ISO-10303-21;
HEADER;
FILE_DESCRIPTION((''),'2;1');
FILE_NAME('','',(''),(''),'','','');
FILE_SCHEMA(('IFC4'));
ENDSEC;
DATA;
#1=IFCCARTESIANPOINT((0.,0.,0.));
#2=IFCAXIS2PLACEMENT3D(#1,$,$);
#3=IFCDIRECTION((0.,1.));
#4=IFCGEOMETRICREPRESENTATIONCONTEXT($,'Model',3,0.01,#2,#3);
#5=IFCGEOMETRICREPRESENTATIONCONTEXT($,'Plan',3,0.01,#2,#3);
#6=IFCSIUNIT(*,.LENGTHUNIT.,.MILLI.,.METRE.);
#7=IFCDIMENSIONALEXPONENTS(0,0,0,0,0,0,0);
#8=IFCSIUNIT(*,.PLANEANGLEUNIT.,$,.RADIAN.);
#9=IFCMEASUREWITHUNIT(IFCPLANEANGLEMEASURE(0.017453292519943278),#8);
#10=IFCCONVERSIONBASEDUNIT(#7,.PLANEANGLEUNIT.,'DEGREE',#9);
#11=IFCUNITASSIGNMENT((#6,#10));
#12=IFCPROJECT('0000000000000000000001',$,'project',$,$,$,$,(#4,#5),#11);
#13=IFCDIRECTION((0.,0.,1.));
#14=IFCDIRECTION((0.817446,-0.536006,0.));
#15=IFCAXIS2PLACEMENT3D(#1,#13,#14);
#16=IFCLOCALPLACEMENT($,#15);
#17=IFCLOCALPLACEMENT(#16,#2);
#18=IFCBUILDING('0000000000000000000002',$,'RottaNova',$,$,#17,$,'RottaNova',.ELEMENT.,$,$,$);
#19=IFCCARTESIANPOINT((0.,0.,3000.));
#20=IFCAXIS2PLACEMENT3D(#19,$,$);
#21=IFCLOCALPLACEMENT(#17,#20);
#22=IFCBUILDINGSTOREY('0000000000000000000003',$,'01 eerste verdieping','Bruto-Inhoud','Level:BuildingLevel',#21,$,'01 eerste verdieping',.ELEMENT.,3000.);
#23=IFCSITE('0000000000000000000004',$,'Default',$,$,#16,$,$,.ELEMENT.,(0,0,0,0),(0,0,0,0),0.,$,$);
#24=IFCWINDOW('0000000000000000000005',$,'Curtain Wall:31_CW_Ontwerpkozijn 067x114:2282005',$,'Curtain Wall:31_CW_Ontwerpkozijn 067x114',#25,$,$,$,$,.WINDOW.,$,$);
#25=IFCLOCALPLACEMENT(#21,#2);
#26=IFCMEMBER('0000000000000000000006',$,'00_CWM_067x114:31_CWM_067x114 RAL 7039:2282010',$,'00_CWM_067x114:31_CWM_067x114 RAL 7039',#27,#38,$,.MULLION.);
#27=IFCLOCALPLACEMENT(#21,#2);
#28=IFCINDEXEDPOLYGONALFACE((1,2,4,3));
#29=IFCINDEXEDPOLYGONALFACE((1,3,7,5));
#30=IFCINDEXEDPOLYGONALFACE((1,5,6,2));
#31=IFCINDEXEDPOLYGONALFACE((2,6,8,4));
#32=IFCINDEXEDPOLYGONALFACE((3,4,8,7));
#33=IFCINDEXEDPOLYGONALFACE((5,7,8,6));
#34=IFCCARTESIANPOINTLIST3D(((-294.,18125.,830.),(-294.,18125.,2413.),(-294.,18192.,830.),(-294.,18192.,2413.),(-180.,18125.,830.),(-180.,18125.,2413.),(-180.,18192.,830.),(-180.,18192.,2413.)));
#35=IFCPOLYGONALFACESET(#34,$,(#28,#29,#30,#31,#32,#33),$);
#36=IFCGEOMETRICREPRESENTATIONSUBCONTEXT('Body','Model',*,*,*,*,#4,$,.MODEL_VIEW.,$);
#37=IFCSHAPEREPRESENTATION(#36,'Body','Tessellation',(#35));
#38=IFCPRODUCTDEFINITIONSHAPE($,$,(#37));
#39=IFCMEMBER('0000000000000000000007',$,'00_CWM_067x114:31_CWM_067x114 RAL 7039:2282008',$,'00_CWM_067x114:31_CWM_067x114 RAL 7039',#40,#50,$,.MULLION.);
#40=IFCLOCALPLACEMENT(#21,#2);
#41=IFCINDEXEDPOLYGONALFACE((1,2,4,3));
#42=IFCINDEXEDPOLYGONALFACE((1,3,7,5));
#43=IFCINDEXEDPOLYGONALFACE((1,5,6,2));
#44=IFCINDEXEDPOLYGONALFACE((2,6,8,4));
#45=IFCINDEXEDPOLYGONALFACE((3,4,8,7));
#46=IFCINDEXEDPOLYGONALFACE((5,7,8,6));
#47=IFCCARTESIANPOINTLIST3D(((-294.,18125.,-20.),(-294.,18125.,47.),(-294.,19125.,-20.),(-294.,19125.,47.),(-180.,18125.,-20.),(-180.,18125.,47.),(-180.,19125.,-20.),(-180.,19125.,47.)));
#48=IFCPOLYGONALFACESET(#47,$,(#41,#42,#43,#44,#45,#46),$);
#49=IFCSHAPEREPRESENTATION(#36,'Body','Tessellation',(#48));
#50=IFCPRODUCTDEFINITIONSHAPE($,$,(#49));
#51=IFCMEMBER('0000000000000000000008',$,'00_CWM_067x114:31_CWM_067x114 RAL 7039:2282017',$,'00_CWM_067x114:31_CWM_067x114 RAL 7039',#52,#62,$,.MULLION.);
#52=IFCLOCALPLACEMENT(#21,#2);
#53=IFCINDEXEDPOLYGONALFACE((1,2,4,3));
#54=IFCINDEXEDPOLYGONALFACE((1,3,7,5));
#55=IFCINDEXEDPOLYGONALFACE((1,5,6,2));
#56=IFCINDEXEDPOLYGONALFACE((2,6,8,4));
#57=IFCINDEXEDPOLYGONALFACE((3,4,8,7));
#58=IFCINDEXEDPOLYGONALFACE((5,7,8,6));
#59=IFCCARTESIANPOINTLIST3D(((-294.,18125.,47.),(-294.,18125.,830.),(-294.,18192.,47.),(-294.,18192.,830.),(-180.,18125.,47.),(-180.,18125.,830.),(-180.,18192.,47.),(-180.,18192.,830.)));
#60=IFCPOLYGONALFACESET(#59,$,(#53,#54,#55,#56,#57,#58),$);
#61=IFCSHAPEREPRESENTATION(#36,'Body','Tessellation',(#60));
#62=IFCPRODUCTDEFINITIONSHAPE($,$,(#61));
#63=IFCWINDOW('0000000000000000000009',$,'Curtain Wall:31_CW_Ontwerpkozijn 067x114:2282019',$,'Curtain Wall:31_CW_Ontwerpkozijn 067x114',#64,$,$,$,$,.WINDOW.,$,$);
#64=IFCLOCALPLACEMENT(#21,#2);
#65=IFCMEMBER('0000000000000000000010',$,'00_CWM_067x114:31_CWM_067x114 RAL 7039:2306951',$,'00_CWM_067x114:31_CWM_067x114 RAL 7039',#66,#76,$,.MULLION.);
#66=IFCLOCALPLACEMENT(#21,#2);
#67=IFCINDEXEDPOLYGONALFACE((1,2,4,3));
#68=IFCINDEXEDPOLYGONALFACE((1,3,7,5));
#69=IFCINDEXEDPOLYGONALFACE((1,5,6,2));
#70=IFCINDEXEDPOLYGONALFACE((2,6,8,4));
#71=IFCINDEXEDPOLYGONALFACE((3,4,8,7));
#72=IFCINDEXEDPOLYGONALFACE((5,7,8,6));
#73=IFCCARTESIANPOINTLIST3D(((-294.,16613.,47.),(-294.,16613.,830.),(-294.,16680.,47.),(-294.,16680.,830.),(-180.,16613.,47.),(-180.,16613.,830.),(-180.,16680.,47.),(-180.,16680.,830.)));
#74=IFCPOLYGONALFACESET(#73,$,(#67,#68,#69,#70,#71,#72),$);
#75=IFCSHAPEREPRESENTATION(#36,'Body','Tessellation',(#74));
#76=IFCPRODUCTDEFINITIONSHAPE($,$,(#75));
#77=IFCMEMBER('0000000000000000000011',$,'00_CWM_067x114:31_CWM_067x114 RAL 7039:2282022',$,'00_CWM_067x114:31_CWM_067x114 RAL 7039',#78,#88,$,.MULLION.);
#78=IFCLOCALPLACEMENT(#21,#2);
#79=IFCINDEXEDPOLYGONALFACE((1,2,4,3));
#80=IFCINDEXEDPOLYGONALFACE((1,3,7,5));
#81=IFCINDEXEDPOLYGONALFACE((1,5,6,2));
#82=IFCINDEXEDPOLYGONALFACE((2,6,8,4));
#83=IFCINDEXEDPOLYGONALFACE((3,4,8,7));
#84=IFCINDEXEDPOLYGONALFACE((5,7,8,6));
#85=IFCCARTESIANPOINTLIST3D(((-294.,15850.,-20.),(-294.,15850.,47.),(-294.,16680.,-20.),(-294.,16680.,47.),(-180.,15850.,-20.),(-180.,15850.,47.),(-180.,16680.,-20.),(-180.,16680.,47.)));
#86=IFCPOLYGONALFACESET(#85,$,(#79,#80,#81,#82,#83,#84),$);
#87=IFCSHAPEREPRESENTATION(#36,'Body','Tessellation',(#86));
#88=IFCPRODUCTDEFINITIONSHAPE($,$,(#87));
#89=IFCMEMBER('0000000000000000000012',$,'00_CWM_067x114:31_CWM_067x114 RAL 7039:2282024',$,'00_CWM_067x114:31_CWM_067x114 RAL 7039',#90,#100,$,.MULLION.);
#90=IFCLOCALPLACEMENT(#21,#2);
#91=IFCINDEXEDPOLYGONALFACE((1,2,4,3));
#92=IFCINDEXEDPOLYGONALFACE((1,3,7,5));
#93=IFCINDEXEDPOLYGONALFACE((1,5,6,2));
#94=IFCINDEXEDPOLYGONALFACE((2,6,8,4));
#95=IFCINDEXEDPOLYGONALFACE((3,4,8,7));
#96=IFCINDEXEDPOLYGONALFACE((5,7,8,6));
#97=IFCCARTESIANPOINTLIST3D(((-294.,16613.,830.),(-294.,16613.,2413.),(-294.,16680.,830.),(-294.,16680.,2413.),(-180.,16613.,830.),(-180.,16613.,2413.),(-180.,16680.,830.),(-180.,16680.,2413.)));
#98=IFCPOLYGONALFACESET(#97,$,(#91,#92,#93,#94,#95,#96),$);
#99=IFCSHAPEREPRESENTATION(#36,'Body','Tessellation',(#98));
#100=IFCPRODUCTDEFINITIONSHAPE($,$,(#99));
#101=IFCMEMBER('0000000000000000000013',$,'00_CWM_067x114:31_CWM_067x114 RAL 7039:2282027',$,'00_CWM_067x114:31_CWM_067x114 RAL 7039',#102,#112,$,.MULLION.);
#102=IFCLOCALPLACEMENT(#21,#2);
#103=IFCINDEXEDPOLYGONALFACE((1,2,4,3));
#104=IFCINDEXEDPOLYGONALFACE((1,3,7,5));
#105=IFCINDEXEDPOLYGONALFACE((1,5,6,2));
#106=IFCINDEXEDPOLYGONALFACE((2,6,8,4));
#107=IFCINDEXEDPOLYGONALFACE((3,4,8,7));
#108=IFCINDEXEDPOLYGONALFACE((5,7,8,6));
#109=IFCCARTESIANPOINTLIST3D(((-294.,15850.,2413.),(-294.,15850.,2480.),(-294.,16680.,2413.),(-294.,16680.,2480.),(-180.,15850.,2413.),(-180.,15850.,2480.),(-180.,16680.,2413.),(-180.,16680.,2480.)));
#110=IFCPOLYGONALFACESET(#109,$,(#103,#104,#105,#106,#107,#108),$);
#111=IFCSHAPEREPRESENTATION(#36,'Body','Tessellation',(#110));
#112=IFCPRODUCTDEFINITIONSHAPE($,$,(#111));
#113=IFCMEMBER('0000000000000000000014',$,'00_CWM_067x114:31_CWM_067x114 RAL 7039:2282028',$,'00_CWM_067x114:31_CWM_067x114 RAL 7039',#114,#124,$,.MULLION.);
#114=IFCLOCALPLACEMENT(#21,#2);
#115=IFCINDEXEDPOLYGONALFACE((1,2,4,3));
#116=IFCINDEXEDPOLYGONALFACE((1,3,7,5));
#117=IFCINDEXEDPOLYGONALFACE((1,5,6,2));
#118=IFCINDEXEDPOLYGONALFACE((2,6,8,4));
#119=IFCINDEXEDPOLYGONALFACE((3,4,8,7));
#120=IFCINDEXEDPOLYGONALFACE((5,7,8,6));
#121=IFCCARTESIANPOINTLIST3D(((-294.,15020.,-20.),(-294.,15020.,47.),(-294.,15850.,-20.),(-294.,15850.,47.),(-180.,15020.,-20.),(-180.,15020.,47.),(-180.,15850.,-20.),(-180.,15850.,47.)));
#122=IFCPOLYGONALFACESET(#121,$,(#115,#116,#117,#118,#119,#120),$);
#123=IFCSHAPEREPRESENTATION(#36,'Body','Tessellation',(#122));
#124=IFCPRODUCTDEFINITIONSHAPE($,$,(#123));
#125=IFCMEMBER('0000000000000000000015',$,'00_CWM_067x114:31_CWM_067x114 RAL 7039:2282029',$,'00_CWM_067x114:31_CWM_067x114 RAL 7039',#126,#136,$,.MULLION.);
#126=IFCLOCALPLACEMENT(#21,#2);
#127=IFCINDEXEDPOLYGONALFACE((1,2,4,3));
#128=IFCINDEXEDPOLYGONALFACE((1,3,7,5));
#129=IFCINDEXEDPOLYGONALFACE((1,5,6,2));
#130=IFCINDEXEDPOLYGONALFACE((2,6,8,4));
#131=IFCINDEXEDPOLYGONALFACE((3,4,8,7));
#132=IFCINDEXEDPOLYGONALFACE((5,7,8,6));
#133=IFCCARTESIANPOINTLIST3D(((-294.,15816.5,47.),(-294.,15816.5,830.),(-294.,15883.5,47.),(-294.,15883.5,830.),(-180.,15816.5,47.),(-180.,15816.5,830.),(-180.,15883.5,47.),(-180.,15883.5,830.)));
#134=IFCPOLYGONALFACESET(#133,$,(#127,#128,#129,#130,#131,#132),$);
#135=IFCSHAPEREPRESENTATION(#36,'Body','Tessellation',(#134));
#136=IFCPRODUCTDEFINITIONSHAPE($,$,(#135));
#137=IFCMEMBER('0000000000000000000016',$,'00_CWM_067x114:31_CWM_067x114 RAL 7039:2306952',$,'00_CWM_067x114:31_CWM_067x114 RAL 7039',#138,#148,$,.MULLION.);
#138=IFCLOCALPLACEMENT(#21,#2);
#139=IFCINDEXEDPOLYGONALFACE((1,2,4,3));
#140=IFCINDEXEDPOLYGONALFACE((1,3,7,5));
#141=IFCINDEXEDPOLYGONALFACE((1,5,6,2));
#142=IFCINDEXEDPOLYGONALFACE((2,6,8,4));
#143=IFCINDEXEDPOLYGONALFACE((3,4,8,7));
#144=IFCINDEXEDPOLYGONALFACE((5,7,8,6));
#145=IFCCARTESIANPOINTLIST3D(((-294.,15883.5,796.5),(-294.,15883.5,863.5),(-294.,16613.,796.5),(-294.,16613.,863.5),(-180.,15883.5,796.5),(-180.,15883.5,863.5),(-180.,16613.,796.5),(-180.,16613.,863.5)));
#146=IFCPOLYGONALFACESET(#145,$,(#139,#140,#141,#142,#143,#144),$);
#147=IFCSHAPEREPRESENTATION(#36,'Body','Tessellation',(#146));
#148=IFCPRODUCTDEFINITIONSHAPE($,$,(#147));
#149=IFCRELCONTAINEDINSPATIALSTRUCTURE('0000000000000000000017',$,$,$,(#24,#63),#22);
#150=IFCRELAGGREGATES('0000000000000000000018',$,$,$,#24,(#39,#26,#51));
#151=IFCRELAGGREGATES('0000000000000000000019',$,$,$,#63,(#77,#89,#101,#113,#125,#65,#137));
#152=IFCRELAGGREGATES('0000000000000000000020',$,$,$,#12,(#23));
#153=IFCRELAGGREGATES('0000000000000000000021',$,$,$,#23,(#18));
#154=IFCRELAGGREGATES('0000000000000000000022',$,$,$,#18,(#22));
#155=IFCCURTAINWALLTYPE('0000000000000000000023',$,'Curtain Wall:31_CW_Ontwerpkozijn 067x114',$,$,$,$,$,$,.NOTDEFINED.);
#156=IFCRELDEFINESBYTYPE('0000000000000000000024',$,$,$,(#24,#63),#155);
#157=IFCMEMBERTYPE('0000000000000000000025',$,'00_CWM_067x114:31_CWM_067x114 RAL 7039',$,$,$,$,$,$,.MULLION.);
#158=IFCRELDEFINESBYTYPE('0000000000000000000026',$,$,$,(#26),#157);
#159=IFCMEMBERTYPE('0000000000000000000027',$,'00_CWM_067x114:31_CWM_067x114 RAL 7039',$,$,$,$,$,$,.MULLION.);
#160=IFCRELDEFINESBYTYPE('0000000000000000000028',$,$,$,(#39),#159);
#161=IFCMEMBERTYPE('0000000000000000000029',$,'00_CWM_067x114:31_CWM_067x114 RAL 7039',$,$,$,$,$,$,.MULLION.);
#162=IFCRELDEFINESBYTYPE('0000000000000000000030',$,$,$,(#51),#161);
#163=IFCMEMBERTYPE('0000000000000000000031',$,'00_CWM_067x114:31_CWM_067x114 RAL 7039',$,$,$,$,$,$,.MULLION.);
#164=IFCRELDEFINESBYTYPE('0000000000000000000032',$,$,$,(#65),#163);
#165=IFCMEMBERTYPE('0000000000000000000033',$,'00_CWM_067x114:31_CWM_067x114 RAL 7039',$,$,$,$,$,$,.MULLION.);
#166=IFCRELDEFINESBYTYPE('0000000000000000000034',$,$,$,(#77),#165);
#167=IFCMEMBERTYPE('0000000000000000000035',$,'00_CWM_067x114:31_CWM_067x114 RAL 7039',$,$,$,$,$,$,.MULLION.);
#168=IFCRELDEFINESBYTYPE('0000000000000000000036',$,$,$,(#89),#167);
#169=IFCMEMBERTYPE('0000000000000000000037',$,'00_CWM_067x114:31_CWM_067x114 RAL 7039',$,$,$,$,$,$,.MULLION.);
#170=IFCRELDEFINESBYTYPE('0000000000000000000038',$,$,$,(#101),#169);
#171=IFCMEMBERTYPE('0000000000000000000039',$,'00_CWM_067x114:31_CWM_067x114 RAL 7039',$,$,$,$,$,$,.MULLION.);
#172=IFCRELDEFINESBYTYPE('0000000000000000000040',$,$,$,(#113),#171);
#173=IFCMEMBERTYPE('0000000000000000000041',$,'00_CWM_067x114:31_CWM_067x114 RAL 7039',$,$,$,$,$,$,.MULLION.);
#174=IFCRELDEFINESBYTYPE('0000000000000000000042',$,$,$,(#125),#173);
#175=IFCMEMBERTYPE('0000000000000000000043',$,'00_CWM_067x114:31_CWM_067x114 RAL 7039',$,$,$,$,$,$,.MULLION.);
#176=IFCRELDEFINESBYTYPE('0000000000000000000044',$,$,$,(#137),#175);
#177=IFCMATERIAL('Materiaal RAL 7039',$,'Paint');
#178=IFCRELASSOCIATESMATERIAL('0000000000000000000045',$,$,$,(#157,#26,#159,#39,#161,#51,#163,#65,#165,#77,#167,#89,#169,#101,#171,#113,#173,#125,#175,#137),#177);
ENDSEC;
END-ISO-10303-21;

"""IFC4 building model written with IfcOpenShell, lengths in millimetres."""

from ifc_helpers import new_model, entity, si_unit, converted_unit, direction, frame, origin, place, context, subcontext, project, spatial, indexed_curve, outline, extrude, source, transform, mapped, material, type_object, type_shapes, element, aggregate, save


model = new_model("IFC4")

# Units and contexts
model_context = context("Model", 3, precision=0.01, world=origin(), true_north=direction((0.0, 1.0)))
plan_context = context("Plan", 3, precision=0.01, world=origin(), true_north=direction((0.0, 1.0)))
body_context = subcontext(model_context, "Body", "Model", "MODEL_VIEW")
ifc_project = project(units=[si_unit("LENGTHUNIT", "METRE", prefix="MILLI"), converted_unit("PLANEANGLEUNIT", "DEGREE", entity("IfcPlaneAngleMeasure", 0.017453292519943278), si_unit("PLANEANGLEUNIT", "RADIAN"), dimensions=[0, 0, 0, 0, 0, 0, 0])], contexts=[model_context, plan_context])

# Site, building, storey
site_placement = place(None, frame((0.0, 0.0, 0.0), z_axis=(0.0, 0.0, 1.0), x_axis=(0.817446, -0.536006, 0.0)))
site = spatial("IfcSite", under=ifc_project, at=site_placement, Name="Default", CompositionType="ELEMENT", RefLatitude=(0, 0, 0, 0), RefLongitude=(0, 0, 0, 0), RefElevation=0.0)
building_placement = place(site_placement, origin())
building = spatial("IfcBuilding", under=site, at=building_placement, Name="RottaNova", LongName="RottaNova", CompositionType="ELEMENT")
storey_placement = place(building_placement, frame((0.0, 0.0, 3000.0)))
storey = spatial("IfcBuildingStorey", under=building, at=storey_placement, Name="01 eerste verdieping", Description="Bruto-Inhoud", ObjectType="Level:BuildingLevel", LongName="01 eerste verdieping", CompositionType="ELEMENT", Elevation=3000.0)

# Windows, members
curtain_wall_type = type_object("IfcCurtainWallType", Name="Curtain Wall:31_CW_Ontwerpkozijn 067x114", PredefinedType="NOTDEFINED")
window_1_placement = place(storey_placement, frame((0.0, 0.0, -3000.0)))
window_1 = element("IfcWindow", 1, at=window_1_placement, inside=storey, type_object=curtain_wall_type, Name="Curtain Wall:31_CW_Ontwerpkozijn 067x114:2282005", ObjectType="Curtain Wall:31_CW_Ontwerpkozijn 067x114", PredefinedType="WINDOW")
ifc_material_1 = material(Name="Materiaal RAL 7039", Category="Paint")
member_type_1 = type_object("IfcMemberType", Name="00_CWM_067x114:31_CWM_067x114 RAL 7039", PredefinedType="MULLION", material=ifc_material_1)
shared_shape_1 = source(origin(), body_context, "Body", "SweptSolid", [
    extrude(outline(indexed_curve([(-33.5, -57.0), (33.5, -57.0), (33.5, 57.0), (-33.5, 57.0), (-33.5, -57.0)], self_intersect=False)), frame((-33.5, -57.0, -1583.0), z_axis=(0.0, 0.0, 1.0), x_axis=(-1.0, 0.0, 0.0)), (0.0, 0.0, 1.0), 1583.0),
])
type_shapes(member_type_1, [shared_shape_1])
member_1_placement = place(window_1_placement, frame((-180.0, 18125.0, 5413.0), z_axis=(0.0, 0.0, 1.0), x_axis=(0.0, -1.0, 0.0)))
member_1 = element("IfcMember", 2, at=member_1_placement, type_object=member_type_1, material=ifc_material_1, Name="00_CWM_067x114:31_CWM_067x114 RAL 7039:2282010", ObjectType="00_CWM_067x114:31_CWM_067x114 RAL 7039", PredefinedType="MULLION", context=body_context, shape_type="MappedRepresentation", body=[
    mapped(shared_shape_1, transform((0.0, 0.0, 0.0), scale=1.0)),
])
member_type_2 = type_object("IfcMemberType", Name="00_CWM_067x114:31_CWM_067x114 RAL 7039", PredefinedType="MULLION", material=ifc_material_1)
shared_shape_2 = source(origin(), body_context, "Body", "SweptSolid", [
    extrude(outline(indexed_curve([(-33.5, -57.0), (33.5, -57.0), (33.5, 57.0), (-33.5, 57.0), (-33.5, -57.0)], self_intersect=False)), frame((-33.5, -57.0, -1000.0), z_axis=(0.0, 0.0, 1.0), x_axis=(-1.0, 0.0, 0.0)), (0.0, 0.0, 1.0), 1000.0),
])
type_shapes(member_type_2, [shared_shape_2])
member_2_placement = place(window_1_placement, frame((-180.0, 18125.0, 2980.0), z_axis=(0.0, -1.0, 0.0), x_axis=(0.0, 0.0, -1.0)))
member_2 = element("IfcMember", 3, at=member_2_placement, type_object=member_type_2, material=ifc_material_1, Name="00_CWM_067x114:31_CWM_067x114 RAL 7039:2282008", ObjectType="00_CWM_067x114:31_CWM_067x114 RAL 7039", PredefinedType="MULLION", context=body_context, shape_type="MappedRepresentation", body=[
    mapped(shared_shape_2, transform((0.0, 0.0, 0.0), scale=1.0)),
])
member_type_3 = type_object("IfcMemberType", Name="00_CWM_067x114:31_CWM_067x114 RAL 7039", PredefinedType="MULLION", material=ifc_material_1)
shared_shape_3 = source(origin(), body_context, "Body", "SweptSolid", [
    extrude(outline(indexed_curve([(-33.5, -57.0), (33.5, -57.0), (33.5, 57.0), (-33.5, 57.0), (-33.5, -57.0)], self_intersect=False)), frame((-33.5, -57.0, -783.0), z_axis=(0.0, 0.0, 1.0), x_axis=(-1.0, 0.0, 0.0)), (0.0, 0.0, 1.0), 783.0),
])
type_shapes(member_type_3, [shared_shape_3])
member_3_placement = place(window_1_placement, frame((-180.0, 18125.0, 3830.0), z_axis=(0.0, 0.0, 1.0), x_axis=(0.0, -1.0, 0.0)))
member_3 = element("IfcMember", 4, at=member_3_placement, type_object=member_type_3, material=ifc_material_1, Name="00_CWM_067x114:31_CWM_067x114 RAL 7039:2282017", ObjectType="00_CWM_067x114:31_CWM_067x114 RAL 7039", PredefinedType="MULLION", context=body_context, shape_type="MappedRepresentation", body=[
    mapped(shared_shape_3, transform((0.0, 0.0, 0.0), scale=1.0)),
])
window_2_placement = place(storey_placement, frame((0.0, 0.0, -3000.0)))
window_2 = element("IfcWindow", 5, at=window_2_placement, inside=storey, type_object=curtain_wall_type, Name="Curtain Wall:31_CW_Ontwerpkozijn 067x114:2282019", ObjectType="Curtain Wall:31_CW_Ontwerpkozijn 067x114", PredefinedType="WINDOW")
member_type_4 = type_object("IfcMemberType", Name="00_CWM_067x114:31_CWM_067x114 RAL 7039", PredefinedType="MULLION", material=ifc_material_1)
shared_shape_4 = source(origin(), body_context, "Body", "SweptSolid", [
    extrude(outline(indexed_curve([(-33.5, -57.0), (33.5, -57.0), (33.5, 57.0), (-33.5, 57.0), (-33.5, -57.0)], self_intersect=False)), frame((-33.5, 57.0, -783.0), z_axis=(0.0, 0.0, 1.0), x_axis=(-1.0, 0.0, 0.0)), (0.0, 0.0, 1.0), 783.0),
])
type_shapes(member_type_4, [shared_shape_4])
member_4_placement = place(window_2_placement, frame((-180.0, 16680.0, 3830.0), z_axis=(0.0, 0.0, 1.0), x_axis=(0.0, 1.0, 0.0)))
member_4 = element("IfcMember", 6, at=member_4_placement, type_object=member_type_4, material=ifc_material_1, Name="00_CWM_067x114:31_CWM_067x114 RAL 7039:2306951", ObjectType="00_CWM_067x114:31_CWM_067x114 RAL 7039", PredefinedType="MULLION", context=body_context, shape_type="MappedRepresentation", body=[
    mapped(shared_shape_4, transform((0.0, 0.0, 0.0), scale=1.0)),
])
member_type_5 = type_object("IfcMemberType", Name="00_CWM_067x114:31_CWM_067x114 RAL 7039", PredefinedType="MULLION", material=ifc_material_1)
shared_shape_5 = source(origin(), body_context, "Body", "SweptSolid", [
    extrude(outline(indexed_curve([(-33.5, -57.0), (33.5, -57.0), (33.5, 57.0), (-33.5, 57.0), (-33.5, -57.0)], self_intersect=False)), frame((-33.5, 57.0, -830.0), z_axis=(0.0, 0.0, 1.0), x_axis=(-1.0, 0.0, 0.0)), (0.0, 0.0, 1.0), 830.0),
])
type_shapes(member_type_5, [shared_shape_5])
member_5_placement = place(window_2_placement, frame((-180.0, 16680.0, 2980.0), z_axis=(0.0, 1.0, 0.0), x_axis=(0.0, 0.0, -1.0)))
member_5 = element("IfcMember", 7, at=member_5_placement, type_object=member_type_5, material=ifc_material_1, Name="00_CWM_067x114:31_CWM_067x114 RAL 7039:2282022", ObjectType="00_CWM_067x114:31_CWM_067x114 RAL 7039", PredefinedType="MULLION", context=body_context, shape_type="MappedRepresentation", body=[
    mapped(shared_shape_5, transform((0.0, 0.0, 0.0), scale=1.0)),
])
member_type_6 = type_object("IfcMemberType", Name="00_CWM_067x114:31_CWM_067x114 RAL 7039", PredefinedType="MULLION", material=ifc_material_1)
shared_shape_6 = source(origin(), body_context, "Body", "SweptSolid", [
    extrude(outline(indexed_curve([(-33.5, -57.0), (33.5, -57.0), (33.5, 57.0), (-33.5, 57.0), (-33.5, -57.0)], self_intersect=False)), frame((-33.5, 57.0, -1583.0), z_axis=(0.0, 0.0, 1.0), x_axis=(-1.0, 0.0, 0.0)), (0.0, 0.0, 1.0), 1583.0),
])
type_shapes(member_type_6, [shared_shape_6])
member_6_placement = place(window_2_placement, frame((-180.0, 16680.0, 5413.0), z_axis=(0.0, 0.0, 1.0), x_axis=(0.0, 1.0, 0.0)))
member_6 = element("IfcMember", 8, at=member_6_placement, type_object=member_type_6, material=ifc_material_1, Name="00_CWM_067x114:31_CWM_067x114 RAL 7039:2282024", ObjectType="00_CWM_067x114:31_CWM_067x114 RAL 7039", PredefinedType="MULLION", context=body_context, shape_type="MappedRepresentation", body=[
    mapped(shared_shape_6, transform((0.0, 0.0, 0.0), scale=1.0)),
])
member_type_7 = type_object("IfcMemberType", Name="00_CWM_067x114:31_CWM_067x114 RAL 7039", PredefinedType="MULLION", material=ifc_material_1)
shared_shape_7 = source(origin(), body_context, "Body", "SweptSolid", [
    extrude(outline(indexed_curve([(-33.5, -57.0), (33.5, -57.0), (33.5, 57.0), (-33.5, 57.0), (-33.5, -57.0)], self_intersect=False)), frame((-33.5, 57.0, -830.0), z_axis=(0.0, 0.0, 1.0), x_axis=(-1.0, 0.0, 0.0)), (0.0, 0.0, 1.0), 830.0),
])
type_shapes(member_type_7, [shared_shape_7])
member_7_placement = place(window_2_placement, frame((-180.0, 15850.0, 5480.0), z_axis=(0.0, -1.0, 0.0), x_axis=(0.0, 0.0, 1.0)))
member_7 = element("IfcMember", 9, at=member_7_placement, type_object=member_type_7, material=ifc_material_1, Name="00_CWM_067x114:31_CWM_067x114 RAL 7039:2282027", ObjectType="00_CWM_067x114:31_CWM_067x114 RAL 7039", PredefinedType="MULLION", context=body_context, shape_type="MappedRepresentation", body=[
    mapped(shared_shape_7, transform((0.0, 0.0, 0.0), scale=1.0)),
])
member_type_8 = type_object("IfcMemberType", Name="00_CWM_067x114:31_CWM_067x114 RAL 7039", PredefinedType="MULLION", material=ifc_material_1)
shared_shape_8 = source(origin(), body_context, "Body", "SweptSolid", [
    extrude(outline(indexed_curve([(-33.5, -57.0), (33.5, -57.0), (33.5, 57.0), (-33.5, 57.0), (-33.5, -57.0)], self_intersect=False)), frame((-33.5, 57.0, -830.0), z_axis=(0.0, 0.0, 1.0), x_axis=(-1.0, 0.0, 0.0)), (0.0, 0.0, 1.0), 830.0),
])
type_shapes(member_type_8, [shared_shape_8])
member_8_placement = place(window_2_placement, frame((-180.0, 15850.0, 2980.0), z_axis=(0.0, 1.0, 0.0), x_axis=(0.0, 0.0, -1.0)))
member_8 = element("IfcMember", 10, at=member_8_placement, type_object=member_type_8, material=ifc_material_1, Name="00_CWM_067x114:31_CWM_067x114 RAL 7039:2282028", ObjectType="00_CWM_067x114:31_CWM_067x114 RAL 7039", PredefinedType="MULLION", context=body_context, shape_type="MappedRepresentation", body=[
    mapped(shared_shape_8, transform((0.0, 0.0, 0.0), scale=1.0)),
])
member_type_9 = type_object("IfcMemberType", Name="00_CWM_067x114:31_CWM_067x114 RAL 7039", PredefinedType="MULLION", material=ifc_material_1)
shared_shape_9 = source(origin(), body_context, "Body", "SweptSolid", [
    extrude(outline(indexed_curve([(-33.5, -57.0), (33.5, -57.0), (33.5, 57.0), (-33.5, 57.0), (-33.5, -57.0)], self_intersect=False)), frame((0.0, 57.0, -783.0), z_axis=(0.0, 0.0, 1.0), x_axis=(-1.0, 0.0, 0.0)), (0.0, 0.0, 1.0), 783.0),
])
type_shapes(member_type_9, [shared_shape_9])
member_9_placement = place(window_2_placement, frame((-180.0, 15850.0, 3047.0), z_axis=(0.0, 0.0, -1.0), x_axis=(0.0, -1.0, 0.0)))
member_9 = element("IfcMember", 11, at=member_9_placement, type_object=member_type_9, material=ifc_material_1, Name="00_CWM_067x114:31_CWM_067x114 RAL 7039:2282029", ObjectType="00_CWM_067x114:31_CWM_067x114 RAL 7039", PredefinedType="MULLION", context=body_context, shape_type="MappedRepresentation", body=[
    mapped(shared_shape_9, transform((0.0, 0.0, 0.0), scale=1.0)),
])
member_type_10 = type_object("IfcMemberType", Name="00_CWM_067x114:31_CWM_067x114 RAL 7039", PredefinedType="MULLION", material=ifc_material_1)
shared_shape_10 = source(origin(), body_context, "Body", "SweptSolid", [
    extrude(outline(indexed_curve([(-33.5, -57.0), (33.5, -57.0), (33.5, 57.0), (-33.5, 57.0), (-33.5, -57.0)], self_intersect=False)), frame((0.0, 57.0, -729.5), z_axis=(0.0, 0.0, 1.0), x_axis=(-1.0, 0.0, 0.0)), (0.0, 0.0, 1.0), 729.5),
])
type_shapes(member_type_10, [shared_shape_10])
member_10_placement = place(window_2_placement, frame((-180.0, 15883.5, 3830.0), z_axis=(0.0, -1.0, 0.0), x_axis=(0.0, 0.0, 1.0)))
member_10 = element("IfcMember", 12, at=member_10_placement, type_object=member_type_10, material=ifc_material_1, Name="00_CWM_067x114:31_CWM_067x114 RAL 7039:2306952", ObjectType="00_CWM_067x114:31_CWM_067x114 RAL 7039", PredefinedType="MULLION", context=body_context, shape_type="MappedRepresentation", body=[
    mapped(shared_shape_10, transform((0.0, 0.0, 0.0), scale=1.0)),
])

aggregate(window_1, [member_2, member_1, member_3])
aggregate(window_2, [member_5, member_6, member_7, member_8, member_9, member_4, member_10])

save(model, "model.ifc")
